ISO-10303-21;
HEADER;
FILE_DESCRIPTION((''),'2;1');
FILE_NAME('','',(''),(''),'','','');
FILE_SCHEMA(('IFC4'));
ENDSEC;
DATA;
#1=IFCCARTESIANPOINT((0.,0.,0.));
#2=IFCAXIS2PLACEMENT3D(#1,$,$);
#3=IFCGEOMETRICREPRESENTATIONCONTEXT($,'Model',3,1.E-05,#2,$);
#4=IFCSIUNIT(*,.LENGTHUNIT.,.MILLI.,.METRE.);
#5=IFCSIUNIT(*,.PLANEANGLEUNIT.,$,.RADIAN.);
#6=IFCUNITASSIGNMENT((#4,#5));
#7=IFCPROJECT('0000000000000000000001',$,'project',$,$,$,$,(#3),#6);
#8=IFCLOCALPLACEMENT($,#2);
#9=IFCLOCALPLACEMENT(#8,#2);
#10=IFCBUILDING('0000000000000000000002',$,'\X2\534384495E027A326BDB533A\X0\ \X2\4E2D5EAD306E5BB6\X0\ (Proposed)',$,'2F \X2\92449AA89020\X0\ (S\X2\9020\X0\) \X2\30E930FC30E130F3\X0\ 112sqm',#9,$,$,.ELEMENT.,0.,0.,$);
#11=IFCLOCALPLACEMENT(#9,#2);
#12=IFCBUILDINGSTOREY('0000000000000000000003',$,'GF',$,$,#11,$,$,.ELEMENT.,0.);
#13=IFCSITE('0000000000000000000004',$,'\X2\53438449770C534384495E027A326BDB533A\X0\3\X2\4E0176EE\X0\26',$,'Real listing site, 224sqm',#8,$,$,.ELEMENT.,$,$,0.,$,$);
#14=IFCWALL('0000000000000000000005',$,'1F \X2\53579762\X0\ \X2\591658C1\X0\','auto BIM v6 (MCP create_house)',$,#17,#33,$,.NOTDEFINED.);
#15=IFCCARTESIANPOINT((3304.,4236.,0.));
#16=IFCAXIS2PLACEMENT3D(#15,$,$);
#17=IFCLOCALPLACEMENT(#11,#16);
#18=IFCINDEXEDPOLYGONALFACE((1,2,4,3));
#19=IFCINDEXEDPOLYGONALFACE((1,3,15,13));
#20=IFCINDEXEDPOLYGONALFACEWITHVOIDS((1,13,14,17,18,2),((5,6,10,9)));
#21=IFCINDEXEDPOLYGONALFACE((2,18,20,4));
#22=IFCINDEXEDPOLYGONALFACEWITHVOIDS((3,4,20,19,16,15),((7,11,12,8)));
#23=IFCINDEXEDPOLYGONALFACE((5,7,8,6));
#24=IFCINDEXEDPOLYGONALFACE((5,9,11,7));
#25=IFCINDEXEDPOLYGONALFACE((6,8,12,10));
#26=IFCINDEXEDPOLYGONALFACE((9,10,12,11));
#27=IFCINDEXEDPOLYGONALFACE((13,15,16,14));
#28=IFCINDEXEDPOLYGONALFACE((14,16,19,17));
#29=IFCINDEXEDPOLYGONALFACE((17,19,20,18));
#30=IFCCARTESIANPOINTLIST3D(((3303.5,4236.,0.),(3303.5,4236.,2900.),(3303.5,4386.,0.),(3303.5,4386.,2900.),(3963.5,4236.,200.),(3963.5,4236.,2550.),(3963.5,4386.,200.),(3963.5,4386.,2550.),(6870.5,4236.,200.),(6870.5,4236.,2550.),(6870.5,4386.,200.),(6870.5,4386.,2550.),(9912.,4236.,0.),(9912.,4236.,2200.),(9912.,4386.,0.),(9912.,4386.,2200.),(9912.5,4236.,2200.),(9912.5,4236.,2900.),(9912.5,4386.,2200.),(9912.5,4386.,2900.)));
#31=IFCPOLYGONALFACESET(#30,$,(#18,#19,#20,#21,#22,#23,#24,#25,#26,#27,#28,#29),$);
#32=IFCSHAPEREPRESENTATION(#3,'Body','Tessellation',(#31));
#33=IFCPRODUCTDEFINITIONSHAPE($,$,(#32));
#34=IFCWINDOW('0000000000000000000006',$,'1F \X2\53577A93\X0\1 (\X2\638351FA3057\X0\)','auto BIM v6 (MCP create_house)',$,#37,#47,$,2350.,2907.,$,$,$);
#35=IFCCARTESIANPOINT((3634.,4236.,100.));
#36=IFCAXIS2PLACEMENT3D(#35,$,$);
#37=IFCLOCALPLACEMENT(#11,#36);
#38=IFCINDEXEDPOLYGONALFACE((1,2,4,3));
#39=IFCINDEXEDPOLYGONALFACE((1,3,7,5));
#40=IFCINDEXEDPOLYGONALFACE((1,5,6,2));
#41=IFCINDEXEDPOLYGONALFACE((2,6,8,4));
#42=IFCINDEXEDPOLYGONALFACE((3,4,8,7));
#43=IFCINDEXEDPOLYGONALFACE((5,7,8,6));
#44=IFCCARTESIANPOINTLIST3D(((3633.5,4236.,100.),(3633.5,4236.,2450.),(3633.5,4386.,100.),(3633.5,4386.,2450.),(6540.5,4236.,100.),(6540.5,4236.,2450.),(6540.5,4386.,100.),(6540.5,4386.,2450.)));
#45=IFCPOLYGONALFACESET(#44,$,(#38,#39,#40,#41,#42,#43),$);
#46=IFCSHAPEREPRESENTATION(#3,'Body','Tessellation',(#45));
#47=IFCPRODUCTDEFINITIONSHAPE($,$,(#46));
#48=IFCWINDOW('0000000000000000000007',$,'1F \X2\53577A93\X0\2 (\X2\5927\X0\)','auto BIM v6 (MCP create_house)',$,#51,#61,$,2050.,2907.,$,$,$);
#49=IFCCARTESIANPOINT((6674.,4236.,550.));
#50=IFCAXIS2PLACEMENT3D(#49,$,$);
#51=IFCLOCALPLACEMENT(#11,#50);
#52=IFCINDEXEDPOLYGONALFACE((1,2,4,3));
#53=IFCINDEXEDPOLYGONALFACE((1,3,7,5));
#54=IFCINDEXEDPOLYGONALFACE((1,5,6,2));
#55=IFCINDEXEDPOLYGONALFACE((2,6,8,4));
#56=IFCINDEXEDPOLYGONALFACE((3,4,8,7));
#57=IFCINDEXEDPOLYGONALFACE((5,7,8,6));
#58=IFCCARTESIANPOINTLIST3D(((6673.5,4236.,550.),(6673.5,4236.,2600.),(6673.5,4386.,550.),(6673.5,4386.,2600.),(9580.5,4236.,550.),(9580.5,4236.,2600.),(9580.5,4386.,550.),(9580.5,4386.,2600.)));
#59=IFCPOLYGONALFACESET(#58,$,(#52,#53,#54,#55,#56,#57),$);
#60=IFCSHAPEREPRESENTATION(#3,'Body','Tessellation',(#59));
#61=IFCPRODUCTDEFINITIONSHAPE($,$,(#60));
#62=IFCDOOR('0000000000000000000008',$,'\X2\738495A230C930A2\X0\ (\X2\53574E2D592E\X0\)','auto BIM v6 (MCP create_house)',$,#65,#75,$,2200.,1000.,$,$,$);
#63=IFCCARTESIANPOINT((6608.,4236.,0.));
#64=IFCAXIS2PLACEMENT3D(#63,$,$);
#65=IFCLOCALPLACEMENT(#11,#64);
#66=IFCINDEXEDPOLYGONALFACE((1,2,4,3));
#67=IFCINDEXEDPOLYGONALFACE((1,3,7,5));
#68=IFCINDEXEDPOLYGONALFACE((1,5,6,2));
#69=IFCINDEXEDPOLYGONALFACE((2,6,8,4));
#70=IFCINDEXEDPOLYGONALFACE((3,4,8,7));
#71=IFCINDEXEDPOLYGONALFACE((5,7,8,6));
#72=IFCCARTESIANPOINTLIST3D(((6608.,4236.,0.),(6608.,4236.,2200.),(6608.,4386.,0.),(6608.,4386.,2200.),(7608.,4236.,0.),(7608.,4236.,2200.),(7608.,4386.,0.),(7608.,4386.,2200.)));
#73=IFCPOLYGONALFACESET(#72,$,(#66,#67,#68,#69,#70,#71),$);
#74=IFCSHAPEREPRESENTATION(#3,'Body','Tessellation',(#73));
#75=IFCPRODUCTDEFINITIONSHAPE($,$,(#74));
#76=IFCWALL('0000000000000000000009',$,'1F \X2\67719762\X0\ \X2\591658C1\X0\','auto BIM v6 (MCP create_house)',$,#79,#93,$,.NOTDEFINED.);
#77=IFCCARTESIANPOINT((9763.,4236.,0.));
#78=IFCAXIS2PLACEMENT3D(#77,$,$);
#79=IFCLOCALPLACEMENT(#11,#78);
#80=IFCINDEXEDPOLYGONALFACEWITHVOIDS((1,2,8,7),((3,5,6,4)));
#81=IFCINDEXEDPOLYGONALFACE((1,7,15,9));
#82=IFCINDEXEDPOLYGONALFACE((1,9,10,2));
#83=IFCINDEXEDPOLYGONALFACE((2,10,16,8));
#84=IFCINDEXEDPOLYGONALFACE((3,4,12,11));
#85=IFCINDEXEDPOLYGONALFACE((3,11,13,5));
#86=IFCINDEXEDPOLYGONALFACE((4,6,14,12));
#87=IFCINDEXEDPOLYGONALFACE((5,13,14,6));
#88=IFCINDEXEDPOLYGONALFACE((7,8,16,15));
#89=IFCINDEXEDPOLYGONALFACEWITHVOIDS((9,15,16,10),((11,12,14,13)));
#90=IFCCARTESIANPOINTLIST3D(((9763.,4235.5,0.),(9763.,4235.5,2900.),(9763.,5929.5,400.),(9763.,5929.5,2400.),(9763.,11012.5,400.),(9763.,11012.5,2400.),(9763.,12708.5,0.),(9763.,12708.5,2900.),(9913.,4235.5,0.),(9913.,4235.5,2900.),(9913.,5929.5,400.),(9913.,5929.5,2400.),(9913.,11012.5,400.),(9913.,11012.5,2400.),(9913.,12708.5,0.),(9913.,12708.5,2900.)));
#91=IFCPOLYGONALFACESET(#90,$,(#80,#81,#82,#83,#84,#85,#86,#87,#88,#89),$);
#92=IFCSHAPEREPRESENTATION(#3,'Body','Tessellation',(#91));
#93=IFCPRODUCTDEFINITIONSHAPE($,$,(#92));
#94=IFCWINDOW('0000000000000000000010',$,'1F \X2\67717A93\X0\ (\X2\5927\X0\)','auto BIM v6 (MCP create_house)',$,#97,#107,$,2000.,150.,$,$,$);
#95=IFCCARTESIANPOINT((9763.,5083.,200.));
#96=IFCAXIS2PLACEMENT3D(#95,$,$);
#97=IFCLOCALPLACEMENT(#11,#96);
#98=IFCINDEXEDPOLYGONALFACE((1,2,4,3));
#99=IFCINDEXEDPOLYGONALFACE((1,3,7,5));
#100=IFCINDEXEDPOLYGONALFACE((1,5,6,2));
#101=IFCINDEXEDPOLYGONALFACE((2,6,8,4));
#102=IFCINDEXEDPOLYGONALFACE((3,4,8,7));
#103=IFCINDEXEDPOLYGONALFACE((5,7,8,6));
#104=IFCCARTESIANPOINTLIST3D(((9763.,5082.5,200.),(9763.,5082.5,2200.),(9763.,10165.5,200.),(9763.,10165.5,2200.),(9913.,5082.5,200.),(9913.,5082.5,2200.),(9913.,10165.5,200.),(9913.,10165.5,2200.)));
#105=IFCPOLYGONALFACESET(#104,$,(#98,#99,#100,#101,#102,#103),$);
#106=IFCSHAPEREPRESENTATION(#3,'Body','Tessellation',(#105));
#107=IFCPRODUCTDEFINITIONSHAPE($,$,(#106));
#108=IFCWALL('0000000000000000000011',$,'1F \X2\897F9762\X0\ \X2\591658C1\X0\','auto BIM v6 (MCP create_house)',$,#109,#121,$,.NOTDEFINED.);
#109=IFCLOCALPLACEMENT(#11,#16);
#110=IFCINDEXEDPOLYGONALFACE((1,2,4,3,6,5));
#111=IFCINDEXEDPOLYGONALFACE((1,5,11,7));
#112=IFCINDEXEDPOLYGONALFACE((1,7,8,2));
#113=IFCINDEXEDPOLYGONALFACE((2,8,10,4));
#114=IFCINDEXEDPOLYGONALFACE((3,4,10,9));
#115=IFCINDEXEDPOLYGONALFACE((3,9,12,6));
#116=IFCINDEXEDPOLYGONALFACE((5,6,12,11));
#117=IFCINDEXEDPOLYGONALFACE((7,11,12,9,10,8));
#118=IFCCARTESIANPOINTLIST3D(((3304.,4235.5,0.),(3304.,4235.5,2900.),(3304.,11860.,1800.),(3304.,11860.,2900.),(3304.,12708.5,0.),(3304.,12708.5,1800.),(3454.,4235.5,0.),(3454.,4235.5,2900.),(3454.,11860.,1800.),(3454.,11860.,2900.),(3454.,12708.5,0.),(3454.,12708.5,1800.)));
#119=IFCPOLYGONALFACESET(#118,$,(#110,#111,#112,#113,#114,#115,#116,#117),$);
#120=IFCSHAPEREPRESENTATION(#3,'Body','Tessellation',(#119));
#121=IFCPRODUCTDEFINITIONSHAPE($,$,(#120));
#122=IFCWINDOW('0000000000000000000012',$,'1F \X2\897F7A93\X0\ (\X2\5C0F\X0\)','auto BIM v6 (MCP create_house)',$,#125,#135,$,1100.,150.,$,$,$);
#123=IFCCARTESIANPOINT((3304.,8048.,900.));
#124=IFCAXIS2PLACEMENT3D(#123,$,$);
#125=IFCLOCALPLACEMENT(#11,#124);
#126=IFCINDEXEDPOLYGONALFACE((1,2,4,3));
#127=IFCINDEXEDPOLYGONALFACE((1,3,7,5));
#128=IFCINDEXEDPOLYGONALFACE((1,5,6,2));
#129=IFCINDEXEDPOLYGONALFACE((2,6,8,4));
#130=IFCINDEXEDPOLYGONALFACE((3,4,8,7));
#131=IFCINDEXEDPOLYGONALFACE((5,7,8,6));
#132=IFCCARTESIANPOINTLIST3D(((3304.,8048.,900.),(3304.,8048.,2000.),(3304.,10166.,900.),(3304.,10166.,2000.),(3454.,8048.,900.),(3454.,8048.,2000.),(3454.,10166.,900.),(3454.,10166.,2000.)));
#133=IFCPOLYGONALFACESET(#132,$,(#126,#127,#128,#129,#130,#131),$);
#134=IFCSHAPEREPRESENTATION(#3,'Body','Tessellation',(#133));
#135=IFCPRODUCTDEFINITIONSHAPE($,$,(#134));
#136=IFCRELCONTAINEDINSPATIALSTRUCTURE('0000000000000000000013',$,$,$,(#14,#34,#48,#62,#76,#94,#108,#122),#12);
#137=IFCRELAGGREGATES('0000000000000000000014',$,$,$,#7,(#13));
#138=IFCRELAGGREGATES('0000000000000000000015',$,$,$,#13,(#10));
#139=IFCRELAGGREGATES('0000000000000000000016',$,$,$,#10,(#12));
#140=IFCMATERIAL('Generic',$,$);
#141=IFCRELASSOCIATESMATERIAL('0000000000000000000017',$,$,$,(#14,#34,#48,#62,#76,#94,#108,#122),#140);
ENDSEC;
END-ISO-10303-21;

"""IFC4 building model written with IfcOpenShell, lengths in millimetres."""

from ifc_helpers import new_model, si_unit, frame, frame_2d, origin, place, context, project, spatial, rectangle, extrude, material, element, fill, save


model = new_model("IFC4")

# Units and contexts
model_context = context("Model", 3, precision=1e-05, world=origin())
ifc_project = project(units=[si_unit("LENGTHUNIT", "METRE", prefix="MILLI"), si_unit("PLANEANGLEUNIT", "RADIAN")], contexts=[model_context])

# Site, building, storey
site_placement = place(None, origin())
site = spatial("IfcSite", under=ifc_project, at=site_placement, Name="千葉県千葉市稲毛区3丁目26", ObjectType="Real listing site, 224sqm", CompositionType="ELEMENT", RefElevation=0.0)
building_placement = place(site_placement, origin())
building = spatial("IfcBuilding", under=site, at=building_placement, Name="千葉市稲毛区 中庭の家 (Proposed)", ObjectType="2F 鉄骨造 (S造) ラーメン 112sqm", CompositionType="ELEMENT", ElevationOfRefHeight=0.0, ElevationOfTerrain=0.0)
storey_placement = place(building_placement, origin())
storey = spatial("IfcBuildingStorey", under=building, at=storey_placement, Name="GF", CompositionType="ELEMENT", Elevation=0.0)

# Shared definitions
ifc_material = material(Name="Generic")

# Wall, openings, windows, door
wall_1_placement = place(storey_placement, frame((3304.0, 4236.0, 0.0)))
wall_1 = element("IfcWall", 1, at=wall_1_placement, inside=storey, material=ifc_material, Name="1F 南面 外壁", Description="auto BIM v6 (MCP create_house)", PredefinedType="NOTDEFINED", context=model_context, shape_type="SweptSolid", body=[
    extrude(rectangle(XDim=6609.0, YDim=150.0, at=frame_2d((3304.0, 75.0))), frame((3304.0, 4236.0, 0.0)), (0.0, 0.0, 1.0), 2900.0),
])
opening_1_placement = place(storey_placement, frame((3634.0, 4236.0, 100.0)))
opening_1 = element("IfcOpeningElement", 2, at=opening_1_placement, cuts=wall_1, PredefinedType="NOTDEFINED", context=model_context, shape_type="SweptSolid", body=[
    extrude(rectangle(XDim=2907.0, YDim=150.0, at=frame_2d((1453.0, 75.0))), frame((3634.0, 4236.0, 100.0)), (0.0, 0.0, 1.0), 2350.0),
])
opening_2_placement = place(storey_placement, frame((6674.0, 4236.0, 550.0)))
opening_2 = element("IfcOpeningElement", 3, at=opening_2_placement, cuts=wall_1, PredefinedType="NOTDEFINED", context=model_context, shape_type="SweptSolid", body=[
    extrude(rectangle(XDim=2907.0, YDim=150.0, at=frame_2d((1453.0, 75.0))), frame((6674.0, 4236.0, 550.0)), (0.0, 0.0, 1.0), 2050.0),
])
opening_3_placement = place(storey_placement, frame((6608.0, 4236.0, 0.0)))
opening_3 = element("IfcOpeningElement", 4, at=opening_3_placement, cuts=wall_1, PredefinedType="NOTDEFINED", context=model_context, shape_type="SweptSolid", body=[
    extrude(rectangle(XDim=1000.0, YDim=150.0, at=frame_2d((500.0, 75.0))), frame((6608.0, 4236.0, 0.0)), (0.0, 0.0, 1.0), 2200.0),
])
window_1_placement = place(storey_placement, frame((3634.0, 4236.0, 100.0)))
window_1 = element("IfcWindow", 5, at=window_1_placement, inside=storey, material=ifc_material, Name="1F 南窓1 (掃出し)", Description="auto BIM v6 (MCP create_house)", OverallHeight=2350.0, OverallWidth=2907.0, context=model_context, shape_type="SweptSolid", body=[
    extrude(rectangle(XDim=2907.0, YDim=150.0, at=frame_2d((1453.0, 75.0))), frame((3634.0, 4236.0, 100.0)), (0.0, 0.0, 1.0), 2350.0),
])
fill(opening_1, window_1)
window_2_placement = place(storey_placement, frame((6674.0, 4236.0, 550.0)))
window_2 = element("IfcWindow", 6, at=window_2_placement, inside=storey, material=ifc_material, Name="1F 南窓2 (大)", Description="auto BIM v6 (MCP create_house)", OverallHeight=2050.0, OverallWidth=2907.0, context=model_context, shape_type="SweptSolid", body=[
    extrude(rectangle(XDim=2907.0, YDim=150.0, at=frame_2d((1453.0, 75.0))), frame((6674.0, 4236.0, 550.0)), (0.0, 0.0, 1.0), 2050.0),
])
fill(opening_2, window_2)
door_placement = place(storey_placement, frame((6608.0, 4236.0, 0.0)))
door = element("IfcDoor", 7, at=door_placement, inside=storey, material=ifc_material, Name="玄関ドア (南中央)", Description="auto BIM v6 (MCP create_house)", OverallHeight=2200.0, OverallWidth=1000.0, context=model_context, shape_type="SweptSolid", body=[
    extrude(rectangle(XDim=1000.0, YDim=150.0, at=frame_2d((500.0, 75.0))), frame((6608.0, 4236.0, 0.0)), (0.0, 0.0, 1.0), 2200.0),
])
fill(opening_3, door)

# Walls, openings, windows
wall_2_placement = place(storey_placement, frame((9763.0, 4236.0, 0.0)))
wall_2 = element("IfcWall", 8, at=wall_2_placement, inside=storey, material=ifc_material, Name="1F 東面 外壁", Description="auto BIM v6 (MCP create_house)", PredefinedType="NOTDEFINED", context=model_context, shape_type="SweptSolid", body=[
    extrude(rectangle(XDim=150.0, YDim=8473.0, at=frame_2d((75.0, 4236.0))), frame((9763.0, 4236.0, 0.0)), (0.0, 0.0, 1.0), 2900.0),
])
opening_4_placement = place(storey_placement, frame((9763.0, 5083.0, 200.0)))
opening_4 = element("IfcOpeningElement", 9, at=opening_4_placement, cuts=wall_2, PredefinedType="NOTDEFINED", context=model_context, shape_type="SweptSolid", body=[
    extrude(rectangle(XDim=150.0, YDim=5083.0, at=frame_2d((75.0, 2541.0))), frame((9763.0, 5083.0, 200.0)), (0.0, 0.0, 1.0), 2000.0),
])
window_3_placement = place(storey_placement, frame((9763.0, 5083.0, 200.0)))
window_3 = element("IfcWindow", 10, at=window_3_placement, inside=storey, material=ifc_material, Name="1F 東窓 (大)", Description="auto BIM v6 (MCP create_house)", OverallHeight=2000.0, OverallWidth=150.0, context=model_context, shape_type="SweptSolid", body=[
    extrude(rectangle(XDim=150.0, YDim=5083.0, at=frame_2d((75.0, 2541.0))), frame((9763.0, 5083.0, 200.0)), (0.0, 0.0, 1.0), 2000.0),
])
fill(opening_4, window_3)
wall_3_placement = place(storey_placement, frame((3304.0, 4236.0, 0.0)))
wall_3 = element("IfcWall", 11, at=wall_3_placement, inside=storey, material=ifc_material, Name="1F 西面 外壁", Description="auto BIM v6 (MCP create_house)", PredefinedType="NOTDEFINED", context=model_context, shape_type="SweptSolid", body=[
    extrude(rectangle(XDim=150.0, YDim=8473.0, at=frame_2d((75.0, 4236.0))), frame((3304.0, 4236.0, 0.0)), (0.0, 0.0, 1.0), 2900.0),
])
opening_5_placement = place(storey_placement, frame((3304.0, 8048.0, 900.0)))
opening_5 = element("IfcOpeningElement", 12, at=opening_5_placement, cuts=wall_3, PredefinedType="NOTDEFINED", context=model_context, shape_type="SweptSolid", body=[
    extrude(rectangle(XDim=150.0, YDim=2118.0, at=frame_2d((75.0, 1059.0))), frame((3304.0, 8048.0, 900.0)), (0.0, 0.0, 1.0), 1100.0),
])
window_4_placement = place(storey_placement, frame((3304.0, 8048.0, 900.0)))
window_4 = element("IfcWindow", 13, at=window_4_placement, inside=storey, material=ifc_material, Name="1F 西窓 (小)", Description="auto BIM v6 (MCP create_house)", OverallHeight=1100.0, OverallWidth=150.0, context=model_context, shape_type="SweptSolid", body=[
    extrude(rectangle(XDim=150.0, YDim=2118.0, at=frame_2d((75.0, 1059.0))), frame((3304.0, 8048.0, 900.0)), (0.0, 0.0, 1.0), 1100.0),
])
fill(opening_5, window_4)

save(model, "model.ifc")
